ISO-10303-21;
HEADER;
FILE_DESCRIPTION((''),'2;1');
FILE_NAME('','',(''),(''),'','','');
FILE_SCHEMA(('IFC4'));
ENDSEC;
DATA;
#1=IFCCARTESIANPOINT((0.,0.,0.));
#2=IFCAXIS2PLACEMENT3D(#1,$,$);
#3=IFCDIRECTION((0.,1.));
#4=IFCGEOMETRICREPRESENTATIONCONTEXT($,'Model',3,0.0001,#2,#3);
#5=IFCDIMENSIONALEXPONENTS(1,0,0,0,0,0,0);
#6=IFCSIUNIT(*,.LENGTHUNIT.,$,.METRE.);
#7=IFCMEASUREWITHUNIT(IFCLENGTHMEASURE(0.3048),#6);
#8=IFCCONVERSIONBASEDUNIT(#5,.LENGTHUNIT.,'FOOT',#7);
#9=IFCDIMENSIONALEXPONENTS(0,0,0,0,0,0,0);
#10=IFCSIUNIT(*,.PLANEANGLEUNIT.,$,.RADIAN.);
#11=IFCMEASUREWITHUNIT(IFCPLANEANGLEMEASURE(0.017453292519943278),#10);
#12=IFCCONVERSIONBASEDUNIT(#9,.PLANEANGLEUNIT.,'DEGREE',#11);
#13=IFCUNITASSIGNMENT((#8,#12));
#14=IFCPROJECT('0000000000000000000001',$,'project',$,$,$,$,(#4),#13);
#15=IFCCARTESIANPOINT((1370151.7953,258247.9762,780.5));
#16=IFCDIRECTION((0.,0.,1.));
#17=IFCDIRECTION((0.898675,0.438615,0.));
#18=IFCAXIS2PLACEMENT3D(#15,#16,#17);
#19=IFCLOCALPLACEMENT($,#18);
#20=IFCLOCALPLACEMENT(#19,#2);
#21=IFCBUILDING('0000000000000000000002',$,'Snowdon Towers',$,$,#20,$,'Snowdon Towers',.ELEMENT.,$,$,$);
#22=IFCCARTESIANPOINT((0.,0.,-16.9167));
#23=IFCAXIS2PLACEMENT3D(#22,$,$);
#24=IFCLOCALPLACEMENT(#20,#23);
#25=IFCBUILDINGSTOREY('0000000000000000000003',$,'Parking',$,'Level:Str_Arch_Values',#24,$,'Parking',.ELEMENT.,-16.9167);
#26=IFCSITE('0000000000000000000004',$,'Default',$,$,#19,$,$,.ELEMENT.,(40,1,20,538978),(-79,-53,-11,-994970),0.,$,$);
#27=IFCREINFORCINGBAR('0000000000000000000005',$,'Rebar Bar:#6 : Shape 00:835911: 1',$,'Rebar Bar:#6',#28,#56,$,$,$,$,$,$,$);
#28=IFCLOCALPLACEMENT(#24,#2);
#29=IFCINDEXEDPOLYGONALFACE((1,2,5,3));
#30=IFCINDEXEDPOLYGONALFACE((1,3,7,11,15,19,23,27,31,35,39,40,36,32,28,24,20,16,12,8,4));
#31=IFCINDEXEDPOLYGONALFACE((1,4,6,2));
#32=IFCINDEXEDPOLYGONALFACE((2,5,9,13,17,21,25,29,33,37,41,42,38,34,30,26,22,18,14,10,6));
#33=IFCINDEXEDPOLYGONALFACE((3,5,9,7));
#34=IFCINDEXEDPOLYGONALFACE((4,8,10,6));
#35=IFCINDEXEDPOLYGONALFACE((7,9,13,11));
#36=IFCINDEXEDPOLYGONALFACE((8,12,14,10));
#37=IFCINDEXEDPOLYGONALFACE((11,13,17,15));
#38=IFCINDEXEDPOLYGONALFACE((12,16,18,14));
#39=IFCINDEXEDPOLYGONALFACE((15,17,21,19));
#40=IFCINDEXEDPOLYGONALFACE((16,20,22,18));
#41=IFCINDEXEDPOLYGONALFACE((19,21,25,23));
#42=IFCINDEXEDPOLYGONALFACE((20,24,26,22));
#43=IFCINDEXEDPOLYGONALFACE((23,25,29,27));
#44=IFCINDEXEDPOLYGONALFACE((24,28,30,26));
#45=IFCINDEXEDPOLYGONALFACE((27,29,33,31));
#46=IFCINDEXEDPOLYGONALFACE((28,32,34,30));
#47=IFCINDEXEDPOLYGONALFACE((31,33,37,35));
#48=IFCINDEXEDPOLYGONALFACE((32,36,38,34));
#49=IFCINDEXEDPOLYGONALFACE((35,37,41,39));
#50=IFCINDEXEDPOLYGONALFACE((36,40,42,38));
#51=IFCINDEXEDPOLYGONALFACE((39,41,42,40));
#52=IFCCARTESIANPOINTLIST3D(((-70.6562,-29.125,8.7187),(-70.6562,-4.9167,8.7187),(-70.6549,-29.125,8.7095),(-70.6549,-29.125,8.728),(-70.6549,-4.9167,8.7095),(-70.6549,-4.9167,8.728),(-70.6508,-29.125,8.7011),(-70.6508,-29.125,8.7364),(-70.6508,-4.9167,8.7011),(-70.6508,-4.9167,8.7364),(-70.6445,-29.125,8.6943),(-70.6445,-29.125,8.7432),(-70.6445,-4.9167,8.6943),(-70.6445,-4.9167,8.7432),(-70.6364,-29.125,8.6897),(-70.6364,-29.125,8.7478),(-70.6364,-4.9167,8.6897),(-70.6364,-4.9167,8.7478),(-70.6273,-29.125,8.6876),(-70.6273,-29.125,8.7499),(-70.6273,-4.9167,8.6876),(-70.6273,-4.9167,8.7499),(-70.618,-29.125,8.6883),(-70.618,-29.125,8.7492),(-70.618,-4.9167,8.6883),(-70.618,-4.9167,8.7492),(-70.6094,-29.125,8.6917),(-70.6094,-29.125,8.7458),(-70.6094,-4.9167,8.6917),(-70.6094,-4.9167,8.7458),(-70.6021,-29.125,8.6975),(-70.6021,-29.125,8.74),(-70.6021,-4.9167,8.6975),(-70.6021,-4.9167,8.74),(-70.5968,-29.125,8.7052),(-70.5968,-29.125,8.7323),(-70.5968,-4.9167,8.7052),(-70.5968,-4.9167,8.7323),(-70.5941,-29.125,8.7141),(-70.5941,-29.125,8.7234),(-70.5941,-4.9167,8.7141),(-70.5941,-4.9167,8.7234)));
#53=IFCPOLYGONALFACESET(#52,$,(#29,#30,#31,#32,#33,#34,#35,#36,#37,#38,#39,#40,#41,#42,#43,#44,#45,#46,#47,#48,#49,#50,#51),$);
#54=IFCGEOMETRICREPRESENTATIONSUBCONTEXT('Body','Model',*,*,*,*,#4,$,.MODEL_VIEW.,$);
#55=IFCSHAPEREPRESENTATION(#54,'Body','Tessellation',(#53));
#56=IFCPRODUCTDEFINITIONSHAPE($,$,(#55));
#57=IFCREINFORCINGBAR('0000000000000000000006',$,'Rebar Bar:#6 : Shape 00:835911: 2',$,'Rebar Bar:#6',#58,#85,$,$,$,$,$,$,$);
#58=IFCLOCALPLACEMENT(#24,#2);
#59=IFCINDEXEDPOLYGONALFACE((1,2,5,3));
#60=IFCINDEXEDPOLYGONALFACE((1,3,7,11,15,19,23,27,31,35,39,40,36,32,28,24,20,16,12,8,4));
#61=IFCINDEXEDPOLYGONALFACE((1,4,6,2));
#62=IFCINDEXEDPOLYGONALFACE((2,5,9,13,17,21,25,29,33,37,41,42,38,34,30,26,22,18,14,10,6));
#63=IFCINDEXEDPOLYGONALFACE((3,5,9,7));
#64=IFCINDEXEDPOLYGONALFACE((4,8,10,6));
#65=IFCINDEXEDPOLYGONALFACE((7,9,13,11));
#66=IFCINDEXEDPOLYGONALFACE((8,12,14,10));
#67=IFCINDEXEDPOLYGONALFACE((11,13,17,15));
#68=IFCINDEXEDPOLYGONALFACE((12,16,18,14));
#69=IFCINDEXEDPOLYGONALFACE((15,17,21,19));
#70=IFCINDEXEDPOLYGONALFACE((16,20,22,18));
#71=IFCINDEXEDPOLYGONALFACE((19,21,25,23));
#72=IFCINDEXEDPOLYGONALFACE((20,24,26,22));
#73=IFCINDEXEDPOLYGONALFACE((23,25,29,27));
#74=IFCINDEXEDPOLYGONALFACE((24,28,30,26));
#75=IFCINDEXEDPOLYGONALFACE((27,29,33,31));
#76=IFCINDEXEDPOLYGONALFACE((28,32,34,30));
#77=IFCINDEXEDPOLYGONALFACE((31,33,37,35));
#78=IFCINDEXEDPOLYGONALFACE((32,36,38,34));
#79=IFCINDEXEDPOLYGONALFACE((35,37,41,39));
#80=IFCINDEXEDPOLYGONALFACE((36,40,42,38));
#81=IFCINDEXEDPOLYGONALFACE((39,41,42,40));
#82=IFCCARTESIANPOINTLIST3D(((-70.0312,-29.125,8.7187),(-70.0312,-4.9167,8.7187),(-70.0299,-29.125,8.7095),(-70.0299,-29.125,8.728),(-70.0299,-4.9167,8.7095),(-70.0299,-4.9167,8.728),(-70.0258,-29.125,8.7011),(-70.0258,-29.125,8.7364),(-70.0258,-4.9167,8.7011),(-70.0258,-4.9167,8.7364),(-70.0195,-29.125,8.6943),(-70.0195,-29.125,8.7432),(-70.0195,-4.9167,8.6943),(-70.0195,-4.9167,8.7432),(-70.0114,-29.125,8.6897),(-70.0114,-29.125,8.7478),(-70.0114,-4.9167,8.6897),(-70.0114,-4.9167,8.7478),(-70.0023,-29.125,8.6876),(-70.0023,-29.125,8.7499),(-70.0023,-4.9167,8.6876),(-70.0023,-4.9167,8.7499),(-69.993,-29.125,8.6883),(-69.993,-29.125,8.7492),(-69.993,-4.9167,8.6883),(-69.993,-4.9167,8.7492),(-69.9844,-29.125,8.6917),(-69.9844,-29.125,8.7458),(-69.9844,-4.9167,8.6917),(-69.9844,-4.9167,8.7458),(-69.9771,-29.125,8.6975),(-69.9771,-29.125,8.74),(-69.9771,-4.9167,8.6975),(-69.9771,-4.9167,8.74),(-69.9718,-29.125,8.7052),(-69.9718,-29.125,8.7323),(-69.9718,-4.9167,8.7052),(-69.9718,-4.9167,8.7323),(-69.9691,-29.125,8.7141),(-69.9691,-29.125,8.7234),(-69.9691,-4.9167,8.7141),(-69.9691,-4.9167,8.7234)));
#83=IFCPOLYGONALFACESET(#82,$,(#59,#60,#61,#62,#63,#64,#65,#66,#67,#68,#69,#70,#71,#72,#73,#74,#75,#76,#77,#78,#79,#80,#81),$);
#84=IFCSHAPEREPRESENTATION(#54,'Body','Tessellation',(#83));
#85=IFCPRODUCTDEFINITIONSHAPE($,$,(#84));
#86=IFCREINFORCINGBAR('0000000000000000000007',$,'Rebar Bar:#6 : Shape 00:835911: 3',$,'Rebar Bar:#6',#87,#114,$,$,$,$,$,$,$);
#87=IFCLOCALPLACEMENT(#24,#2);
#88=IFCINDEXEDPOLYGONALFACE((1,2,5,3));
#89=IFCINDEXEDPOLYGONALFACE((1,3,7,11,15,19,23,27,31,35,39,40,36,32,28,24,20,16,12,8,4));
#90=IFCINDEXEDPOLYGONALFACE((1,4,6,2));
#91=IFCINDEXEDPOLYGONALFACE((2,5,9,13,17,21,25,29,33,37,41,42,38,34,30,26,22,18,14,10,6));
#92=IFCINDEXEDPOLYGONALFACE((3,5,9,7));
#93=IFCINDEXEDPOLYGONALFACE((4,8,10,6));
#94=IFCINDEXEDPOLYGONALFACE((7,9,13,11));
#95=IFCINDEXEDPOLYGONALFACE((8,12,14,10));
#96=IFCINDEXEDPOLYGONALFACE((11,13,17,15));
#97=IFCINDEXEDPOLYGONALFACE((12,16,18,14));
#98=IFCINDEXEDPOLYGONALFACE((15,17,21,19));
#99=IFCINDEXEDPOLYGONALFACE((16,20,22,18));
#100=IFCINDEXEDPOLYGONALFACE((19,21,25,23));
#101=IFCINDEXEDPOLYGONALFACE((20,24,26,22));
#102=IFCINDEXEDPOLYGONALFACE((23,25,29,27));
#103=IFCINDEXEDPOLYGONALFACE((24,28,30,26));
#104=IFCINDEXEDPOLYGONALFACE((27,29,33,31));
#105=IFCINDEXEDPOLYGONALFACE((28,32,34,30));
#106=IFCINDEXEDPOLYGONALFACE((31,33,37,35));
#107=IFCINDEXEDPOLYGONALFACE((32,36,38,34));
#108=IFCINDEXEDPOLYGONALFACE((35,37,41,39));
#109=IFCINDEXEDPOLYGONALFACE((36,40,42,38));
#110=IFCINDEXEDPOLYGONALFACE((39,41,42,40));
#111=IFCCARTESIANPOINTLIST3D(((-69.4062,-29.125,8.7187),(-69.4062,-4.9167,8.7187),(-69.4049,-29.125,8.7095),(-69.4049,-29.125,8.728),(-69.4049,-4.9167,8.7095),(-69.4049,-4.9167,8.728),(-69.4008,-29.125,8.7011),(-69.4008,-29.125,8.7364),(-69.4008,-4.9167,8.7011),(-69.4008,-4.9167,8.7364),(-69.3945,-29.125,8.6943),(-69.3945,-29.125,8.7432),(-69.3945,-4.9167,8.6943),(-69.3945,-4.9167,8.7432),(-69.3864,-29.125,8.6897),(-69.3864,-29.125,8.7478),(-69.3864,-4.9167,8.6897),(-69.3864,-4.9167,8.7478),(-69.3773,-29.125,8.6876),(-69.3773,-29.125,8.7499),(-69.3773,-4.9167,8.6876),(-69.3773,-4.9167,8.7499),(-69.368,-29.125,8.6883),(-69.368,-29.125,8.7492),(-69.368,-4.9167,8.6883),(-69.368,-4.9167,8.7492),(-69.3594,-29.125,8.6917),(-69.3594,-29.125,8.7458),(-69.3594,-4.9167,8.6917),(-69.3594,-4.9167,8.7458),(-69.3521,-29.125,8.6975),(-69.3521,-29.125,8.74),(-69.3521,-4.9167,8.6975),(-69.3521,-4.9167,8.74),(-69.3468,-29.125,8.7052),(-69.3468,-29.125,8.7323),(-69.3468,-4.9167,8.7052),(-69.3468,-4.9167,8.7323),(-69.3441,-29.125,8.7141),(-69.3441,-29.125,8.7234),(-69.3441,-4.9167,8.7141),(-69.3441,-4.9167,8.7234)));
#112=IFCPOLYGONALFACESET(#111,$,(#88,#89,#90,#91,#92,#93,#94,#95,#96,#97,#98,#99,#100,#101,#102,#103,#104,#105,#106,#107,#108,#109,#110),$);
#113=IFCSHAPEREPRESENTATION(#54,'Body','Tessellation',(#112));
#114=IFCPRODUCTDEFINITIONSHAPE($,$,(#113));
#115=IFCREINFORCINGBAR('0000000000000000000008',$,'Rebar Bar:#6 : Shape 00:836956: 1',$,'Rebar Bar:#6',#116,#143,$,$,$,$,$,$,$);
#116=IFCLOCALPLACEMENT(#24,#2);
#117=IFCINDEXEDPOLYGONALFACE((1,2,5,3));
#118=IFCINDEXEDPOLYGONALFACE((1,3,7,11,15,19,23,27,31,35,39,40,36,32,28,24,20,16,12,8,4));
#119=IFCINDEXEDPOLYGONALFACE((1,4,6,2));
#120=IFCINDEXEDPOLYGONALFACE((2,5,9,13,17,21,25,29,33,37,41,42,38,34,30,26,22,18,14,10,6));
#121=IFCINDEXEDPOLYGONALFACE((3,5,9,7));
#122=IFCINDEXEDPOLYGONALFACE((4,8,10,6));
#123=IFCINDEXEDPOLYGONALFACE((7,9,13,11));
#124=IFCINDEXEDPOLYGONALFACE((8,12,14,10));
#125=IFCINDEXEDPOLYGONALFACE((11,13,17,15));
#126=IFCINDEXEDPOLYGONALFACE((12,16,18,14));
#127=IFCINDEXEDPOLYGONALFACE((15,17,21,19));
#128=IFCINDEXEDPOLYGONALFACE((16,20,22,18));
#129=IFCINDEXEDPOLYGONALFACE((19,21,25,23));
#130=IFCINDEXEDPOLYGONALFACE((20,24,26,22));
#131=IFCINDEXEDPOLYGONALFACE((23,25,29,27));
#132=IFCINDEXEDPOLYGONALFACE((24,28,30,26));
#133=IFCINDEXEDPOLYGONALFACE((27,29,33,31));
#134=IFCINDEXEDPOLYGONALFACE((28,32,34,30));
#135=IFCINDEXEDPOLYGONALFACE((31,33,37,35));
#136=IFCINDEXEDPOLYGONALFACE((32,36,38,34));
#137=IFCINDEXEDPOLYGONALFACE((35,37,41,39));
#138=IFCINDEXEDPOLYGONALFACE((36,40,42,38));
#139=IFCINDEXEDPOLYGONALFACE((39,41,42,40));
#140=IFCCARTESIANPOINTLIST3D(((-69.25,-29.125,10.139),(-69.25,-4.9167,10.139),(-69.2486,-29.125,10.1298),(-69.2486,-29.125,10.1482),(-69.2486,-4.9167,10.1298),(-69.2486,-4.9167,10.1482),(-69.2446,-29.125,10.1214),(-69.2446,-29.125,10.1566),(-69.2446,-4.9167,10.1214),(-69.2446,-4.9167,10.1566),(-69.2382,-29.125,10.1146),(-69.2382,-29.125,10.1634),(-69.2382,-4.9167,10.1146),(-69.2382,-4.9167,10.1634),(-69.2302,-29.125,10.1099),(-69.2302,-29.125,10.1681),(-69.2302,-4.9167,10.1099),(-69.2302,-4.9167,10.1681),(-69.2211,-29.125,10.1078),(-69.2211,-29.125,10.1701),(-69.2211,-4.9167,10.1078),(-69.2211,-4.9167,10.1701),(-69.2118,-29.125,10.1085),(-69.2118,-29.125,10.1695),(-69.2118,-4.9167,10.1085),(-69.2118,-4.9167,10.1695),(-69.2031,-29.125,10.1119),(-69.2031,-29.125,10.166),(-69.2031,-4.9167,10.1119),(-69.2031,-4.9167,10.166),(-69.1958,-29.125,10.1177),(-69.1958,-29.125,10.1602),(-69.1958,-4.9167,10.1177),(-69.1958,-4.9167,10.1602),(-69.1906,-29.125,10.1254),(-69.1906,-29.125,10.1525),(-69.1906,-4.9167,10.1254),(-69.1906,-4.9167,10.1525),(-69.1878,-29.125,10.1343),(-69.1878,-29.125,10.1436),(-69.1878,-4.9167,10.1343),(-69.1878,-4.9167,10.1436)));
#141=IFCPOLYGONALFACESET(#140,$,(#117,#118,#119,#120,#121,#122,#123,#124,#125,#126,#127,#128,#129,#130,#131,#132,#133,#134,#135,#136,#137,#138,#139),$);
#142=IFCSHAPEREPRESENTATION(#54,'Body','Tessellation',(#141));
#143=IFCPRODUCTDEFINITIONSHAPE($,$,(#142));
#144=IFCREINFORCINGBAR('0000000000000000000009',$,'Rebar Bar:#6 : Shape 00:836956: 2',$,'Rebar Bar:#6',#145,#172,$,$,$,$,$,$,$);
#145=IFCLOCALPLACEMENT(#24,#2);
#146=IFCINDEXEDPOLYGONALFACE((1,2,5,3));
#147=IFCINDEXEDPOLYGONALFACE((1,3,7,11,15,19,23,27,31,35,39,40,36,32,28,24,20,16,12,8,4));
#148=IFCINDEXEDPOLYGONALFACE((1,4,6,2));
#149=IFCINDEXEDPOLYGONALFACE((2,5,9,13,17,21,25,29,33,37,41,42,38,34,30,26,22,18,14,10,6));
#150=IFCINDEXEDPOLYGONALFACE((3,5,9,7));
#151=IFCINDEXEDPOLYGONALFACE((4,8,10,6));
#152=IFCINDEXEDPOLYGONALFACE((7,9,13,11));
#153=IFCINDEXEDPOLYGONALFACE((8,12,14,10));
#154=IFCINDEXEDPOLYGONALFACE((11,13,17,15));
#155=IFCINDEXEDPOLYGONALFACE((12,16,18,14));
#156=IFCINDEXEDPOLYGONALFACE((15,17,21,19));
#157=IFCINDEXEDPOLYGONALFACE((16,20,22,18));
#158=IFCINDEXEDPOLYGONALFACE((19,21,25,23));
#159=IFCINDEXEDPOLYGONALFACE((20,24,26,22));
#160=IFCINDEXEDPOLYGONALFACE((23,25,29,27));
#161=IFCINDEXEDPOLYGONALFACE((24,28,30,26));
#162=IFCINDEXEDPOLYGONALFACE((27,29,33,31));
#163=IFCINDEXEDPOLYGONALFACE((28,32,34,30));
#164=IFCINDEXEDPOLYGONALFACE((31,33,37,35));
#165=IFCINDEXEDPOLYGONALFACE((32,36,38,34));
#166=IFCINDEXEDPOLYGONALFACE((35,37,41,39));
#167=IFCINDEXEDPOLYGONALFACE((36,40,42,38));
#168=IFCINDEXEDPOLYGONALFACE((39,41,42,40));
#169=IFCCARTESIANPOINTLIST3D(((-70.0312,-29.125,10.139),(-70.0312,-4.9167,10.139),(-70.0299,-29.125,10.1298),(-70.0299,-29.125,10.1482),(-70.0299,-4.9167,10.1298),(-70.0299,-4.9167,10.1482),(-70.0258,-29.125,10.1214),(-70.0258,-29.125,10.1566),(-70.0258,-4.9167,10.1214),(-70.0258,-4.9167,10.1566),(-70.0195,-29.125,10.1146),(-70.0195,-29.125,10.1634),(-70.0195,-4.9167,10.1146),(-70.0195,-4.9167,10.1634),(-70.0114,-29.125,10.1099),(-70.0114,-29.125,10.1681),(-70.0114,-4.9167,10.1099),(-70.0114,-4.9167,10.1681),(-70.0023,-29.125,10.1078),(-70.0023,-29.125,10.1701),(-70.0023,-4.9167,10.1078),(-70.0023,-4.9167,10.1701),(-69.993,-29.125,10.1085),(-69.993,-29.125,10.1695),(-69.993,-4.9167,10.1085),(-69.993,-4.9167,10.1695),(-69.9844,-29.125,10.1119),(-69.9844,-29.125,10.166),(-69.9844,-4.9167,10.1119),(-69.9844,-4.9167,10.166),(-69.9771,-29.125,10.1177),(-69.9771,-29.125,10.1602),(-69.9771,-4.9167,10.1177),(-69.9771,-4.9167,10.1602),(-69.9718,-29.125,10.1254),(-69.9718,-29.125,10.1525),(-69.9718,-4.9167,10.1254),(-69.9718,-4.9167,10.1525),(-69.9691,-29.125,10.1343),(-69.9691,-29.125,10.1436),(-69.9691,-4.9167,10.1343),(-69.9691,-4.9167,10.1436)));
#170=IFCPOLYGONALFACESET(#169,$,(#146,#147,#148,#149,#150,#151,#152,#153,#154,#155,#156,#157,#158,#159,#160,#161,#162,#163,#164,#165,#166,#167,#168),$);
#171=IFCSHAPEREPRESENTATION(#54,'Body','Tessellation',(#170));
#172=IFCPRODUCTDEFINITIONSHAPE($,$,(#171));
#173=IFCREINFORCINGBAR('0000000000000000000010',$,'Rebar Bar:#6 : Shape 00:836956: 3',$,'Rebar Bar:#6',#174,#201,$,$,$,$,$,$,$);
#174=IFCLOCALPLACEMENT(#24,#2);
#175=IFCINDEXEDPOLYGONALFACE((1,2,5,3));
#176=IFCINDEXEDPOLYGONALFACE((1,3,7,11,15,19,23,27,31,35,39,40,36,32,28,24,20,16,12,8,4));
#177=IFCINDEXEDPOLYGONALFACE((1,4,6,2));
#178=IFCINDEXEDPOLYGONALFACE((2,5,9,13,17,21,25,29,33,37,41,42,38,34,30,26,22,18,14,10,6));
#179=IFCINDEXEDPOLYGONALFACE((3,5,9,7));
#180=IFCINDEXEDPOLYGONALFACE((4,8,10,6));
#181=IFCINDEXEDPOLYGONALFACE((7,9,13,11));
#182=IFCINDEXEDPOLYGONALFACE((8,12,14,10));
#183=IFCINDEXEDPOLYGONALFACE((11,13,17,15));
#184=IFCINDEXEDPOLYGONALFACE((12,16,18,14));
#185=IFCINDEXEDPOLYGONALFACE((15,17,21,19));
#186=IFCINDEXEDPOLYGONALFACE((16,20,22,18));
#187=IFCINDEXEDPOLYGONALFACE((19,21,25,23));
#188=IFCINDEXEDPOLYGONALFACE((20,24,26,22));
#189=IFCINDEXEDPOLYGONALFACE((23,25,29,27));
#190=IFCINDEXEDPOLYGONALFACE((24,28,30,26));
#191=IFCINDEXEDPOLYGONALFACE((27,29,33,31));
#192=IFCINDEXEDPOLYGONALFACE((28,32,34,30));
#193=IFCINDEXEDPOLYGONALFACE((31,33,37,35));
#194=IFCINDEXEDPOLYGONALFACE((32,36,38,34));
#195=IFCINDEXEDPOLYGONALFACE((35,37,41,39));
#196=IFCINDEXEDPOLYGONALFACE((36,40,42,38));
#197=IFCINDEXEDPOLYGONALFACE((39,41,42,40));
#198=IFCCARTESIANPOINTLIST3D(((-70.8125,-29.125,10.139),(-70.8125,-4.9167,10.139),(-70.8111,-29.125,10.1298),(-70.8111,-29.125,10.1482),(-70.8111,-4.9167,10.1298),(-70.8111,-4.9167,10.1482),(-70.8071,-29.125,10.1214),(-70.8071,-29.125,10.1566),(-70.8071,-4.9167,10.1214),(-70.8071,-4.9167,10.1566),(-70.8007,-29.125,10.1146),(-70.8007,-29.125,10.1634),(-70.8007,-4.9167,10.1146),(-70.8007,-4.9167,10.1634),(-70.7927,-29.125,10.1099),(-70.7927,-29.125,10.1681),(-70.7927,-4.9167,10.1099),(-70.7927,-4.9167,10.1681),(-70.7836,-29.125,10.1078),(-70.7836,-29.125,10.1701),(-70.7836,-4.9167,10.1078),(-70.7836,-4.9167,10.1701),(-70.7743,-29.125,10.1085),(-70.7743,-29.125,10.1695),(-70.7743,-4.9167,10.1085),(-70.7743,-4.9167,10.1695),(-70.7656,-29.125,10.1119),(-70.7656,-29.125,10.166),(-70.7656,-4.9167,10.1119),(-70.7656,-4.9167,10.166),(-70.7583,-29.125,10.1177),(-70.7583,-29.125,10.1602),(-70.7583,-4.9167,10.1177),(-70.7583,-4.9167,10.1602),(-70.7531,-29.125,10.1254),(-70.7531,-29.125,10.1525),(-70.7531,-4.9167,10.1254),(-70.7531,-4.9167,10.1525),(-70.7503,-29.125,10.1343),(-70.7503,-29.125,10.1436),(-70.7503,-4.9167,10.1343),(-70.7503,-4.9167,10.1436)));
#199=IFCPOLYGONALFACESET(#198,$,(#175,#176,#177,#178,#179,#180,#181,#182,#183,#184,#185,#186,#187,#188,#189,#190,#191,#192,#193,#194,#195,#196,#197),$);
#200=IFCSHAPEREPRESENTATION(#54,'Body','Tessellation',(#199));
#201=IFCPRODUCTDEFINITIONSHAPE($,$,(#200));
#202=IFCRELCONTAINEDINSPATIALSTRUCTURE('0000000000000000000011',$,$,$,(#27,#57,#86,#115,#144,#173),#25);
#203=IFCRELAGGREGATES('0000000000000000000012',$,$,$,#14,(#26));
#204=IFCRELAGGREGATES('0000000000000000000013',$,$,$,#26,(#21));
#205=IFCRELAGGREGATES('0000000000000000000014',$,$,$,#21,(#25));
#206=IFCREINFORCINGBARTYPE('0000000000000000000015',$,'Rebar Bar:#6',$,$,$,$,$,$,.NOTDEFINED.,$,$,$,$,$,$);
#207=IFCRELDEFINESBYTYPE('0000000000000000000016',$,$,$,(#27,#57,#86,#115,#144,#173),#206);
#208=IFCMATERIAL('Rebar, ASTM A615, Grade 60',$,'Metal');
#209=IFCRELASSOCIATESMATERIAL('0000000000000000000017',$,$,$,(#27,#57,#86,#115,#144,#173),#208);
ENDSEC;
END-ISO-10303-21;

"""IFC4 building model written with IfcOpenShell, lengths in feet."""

from ifc_helpers import new_model, entity, si_unit, converted_unit, direction, frame, origin, place, context, subcontext, project, spatial, material, type_object, element, save


model = new_model("IFC4")

# Units and contexts
model_context = context("Model", 3, precision=0.0001, world=origin(), true_north=direction((0.0, 1.0)))
body_context = subcontext(model_context, "Body", "Model", "MODEL_VIEW")
ifc_project = project(units=[converted_unit("LENGTHUNIT", "FOOT", entity("IfcLengthMeasure", 0.3048), si_unit("LENGTHUNIT", "METRE"), dimensions=[1, 0, 0, 0, 0, 0, 0]), converted_unit("PLANEANGLEUNIT", "DEGREE", entity("IfcPlaneAngleMeasure", 0.017453292519943278), si_unit("PLANEANGLEUNIT", "RADIAN"), dimensions=[0, 0, 0, 0, 0, 0, 0])], contexts=[model_context])

# Site, building, storey
site_placement = place(None, frame((1370151.7953, 258247.9762, 780.5), z_axis=(0.0, 0.0, 1.0), x_axis=(0.898675, 0.438615, 0.0)))
site = spatial("IfcSite", under=ifc_project, at=site_placement, Name="Default", CompositionType="ELEMENT", RefLatitude=(40, 1, 20, 538978), RefLongitude=(-79, -53, -11, -994970), RefElevation=0.0)
building_placement = place(site_placement, origin())
building = spatial("IfcBuilding", under=site, at=building_placement, Name="Snowdon Towers", LongName="Snowdon Towers", CompositionType="ELEMENT")
storey_placement = place(building_placement, frame((0.0, 0.0, -16.9167)))
storey = spatial("IfcBuildingStorey", under=building, at=storey_placement, Name="Parking", ObjectType="Level:Str_Arch_Values", LongName="Parking", CompositionType="ELEMENT", Elevation=-16.9167)

# Reinforcing bars
ifc_material = material(Name="Rebar, ASTM A615, Grade 60", Category="Metal")
reinforcing_bar_type = type_object("IfcReinforcingBarType", Name="Rebar Bar:#6", PredefinedType="NOTDEFINED")
reinforcing_bar_1_placement = place(storey_placement, origin())
element("IfcReinforcingBar", 1, at=reinforcing_bar_1_placement, inside=storey, type_object=reinforcing_bar_type, material=ifc_material, Name="Rebar Bar:#6 : Shape 00:835911: 1", ObjectType="Rebar Bar:#6", context=body_context, shape_type="AdvancedSweptSolid", body=[
    entity("IfcSweptDiskSolid", entity("IfcIndexedPolyCurve", entity("IfcCartesianPointList3D", [[-70.625, -4.9167, 8.7187], [-70.625, -29.125, 8.7187]]), None, False), 0.0312, None, 0.0, 1.0),
])
reinforcing_bar_2_placement = place(storey_placement, origin())
element("IfcReinforcingBar", 2, at=reinforcing_bar_2_placement, inside=storey, type_object=reinforcing_bar_type, material=ifc_material, Name="Rebar Bar:#6 : Shape 00:835911: 2", ObjectType="Rebar Bar:#6", context=body_context, shape_type="AdvancedSweptSolid", body=[
    entity("IfcSweptDiskSolid", entity("IfcIndexedPolyCurve", entity("IfcCartesianPointList3D", [[-70.0, -4.9167, 8.7187], [-70.0, -29.125, 8.7187]]), None, False), 0.0312, None, 0.0, 1.0),
])
reinforcing_bar_3_placement = place(storey_placement, origin())
element("IfcReinforcingBar", 3, at=reinforcing_bar_3_placement, inside=storey, type_object=reinforcing_bar_type, material=ifc_material, Name="Rebar Bar:#6 : Shape 00:835911: 3", ObjectType="Rebar Bar:#6", context=body_context, shape_type="AdvancedSweptSolid", body=[
    entity("IfcSweptDiskSolid", entity("IfcIndexedPolyCurve", entity("IfcCartesianPointList3D", [[-69.375, -4.9167, 8.7187], [-69.375, -29.125, 8.7187]]), None, False), 0.0312, None, 0.0, 1.0),
])
reinforcing_bar_4_placement = place(storey_placement, origin())
element("IfcReinforcingBar", 4, at=reinforcing_bar_4_placement, inside=storey, type_object=reinforcing_bar_type, material=ifc_material, Name="Rebar Bar:#6 : Shape 00:836956: 1", ObjectType="Rebar Bar:#6", context=body_context, shape_type="AdvancedSweptSolid", body=[
    entity("IfcSweptDiskSolid", entity("IfcIndexedPolyCurve", entity("IfcCartesianPointList3D", [[-69.2187, -4.9167, 10.139], [-69.2187, -29.125, 10.139]]), None, False), 0.0312, None, 0.0, 1.0),
])
reinforcing_bar_5_placement = place(storey_placement, origin())
element("IfcReinforcingBar", 5, at=reinforcing_bar_5_placement, inside=storey, type_object=reinforcing_bar_type, material=ifc_material, Name="Rebar Bar:#6 : Shape 00:836956: 2", ObjectType="Rebar Bar:#6", context=body_context, shape_type="AdvancedSweptSolid", body=[
    entity("IfcSweptDiskSolid", entity("IfcIndexedPolyCurve", entity("IfcCartesianPointList3D", [[-70.0, -4.9167, 10.139], [-70.0, -29.125, 10.139]]), None, False), 0.0312, None, 0.0, 1.0),
])
reinforcing_bar_6_placement = place(storey_placement, origin())
element("IfcReinforcingBar", 6, at=reinforcing_bar_6_placement, inside=storey, type_object=reinforcing_bar_type, material=ifc_material, Name="Rebar Bar:#6 : Shape 00:836956: 3", ObjectType="Rebar Bar:#6", context=body_context, shape_type="AdvancedSweptSolid", body=[
    entity("IfcSweptDiskSolid", entity("IfcIndexedPolyCurve", entity("IfcCartesianPointList3D", [[-70.7812, -4.9167, 10.139], [-70.7812, -29.125, 10.139]]), None, False), 0.0312, None, 0.0, 1.0),
])

save(model, "model.ifc")
